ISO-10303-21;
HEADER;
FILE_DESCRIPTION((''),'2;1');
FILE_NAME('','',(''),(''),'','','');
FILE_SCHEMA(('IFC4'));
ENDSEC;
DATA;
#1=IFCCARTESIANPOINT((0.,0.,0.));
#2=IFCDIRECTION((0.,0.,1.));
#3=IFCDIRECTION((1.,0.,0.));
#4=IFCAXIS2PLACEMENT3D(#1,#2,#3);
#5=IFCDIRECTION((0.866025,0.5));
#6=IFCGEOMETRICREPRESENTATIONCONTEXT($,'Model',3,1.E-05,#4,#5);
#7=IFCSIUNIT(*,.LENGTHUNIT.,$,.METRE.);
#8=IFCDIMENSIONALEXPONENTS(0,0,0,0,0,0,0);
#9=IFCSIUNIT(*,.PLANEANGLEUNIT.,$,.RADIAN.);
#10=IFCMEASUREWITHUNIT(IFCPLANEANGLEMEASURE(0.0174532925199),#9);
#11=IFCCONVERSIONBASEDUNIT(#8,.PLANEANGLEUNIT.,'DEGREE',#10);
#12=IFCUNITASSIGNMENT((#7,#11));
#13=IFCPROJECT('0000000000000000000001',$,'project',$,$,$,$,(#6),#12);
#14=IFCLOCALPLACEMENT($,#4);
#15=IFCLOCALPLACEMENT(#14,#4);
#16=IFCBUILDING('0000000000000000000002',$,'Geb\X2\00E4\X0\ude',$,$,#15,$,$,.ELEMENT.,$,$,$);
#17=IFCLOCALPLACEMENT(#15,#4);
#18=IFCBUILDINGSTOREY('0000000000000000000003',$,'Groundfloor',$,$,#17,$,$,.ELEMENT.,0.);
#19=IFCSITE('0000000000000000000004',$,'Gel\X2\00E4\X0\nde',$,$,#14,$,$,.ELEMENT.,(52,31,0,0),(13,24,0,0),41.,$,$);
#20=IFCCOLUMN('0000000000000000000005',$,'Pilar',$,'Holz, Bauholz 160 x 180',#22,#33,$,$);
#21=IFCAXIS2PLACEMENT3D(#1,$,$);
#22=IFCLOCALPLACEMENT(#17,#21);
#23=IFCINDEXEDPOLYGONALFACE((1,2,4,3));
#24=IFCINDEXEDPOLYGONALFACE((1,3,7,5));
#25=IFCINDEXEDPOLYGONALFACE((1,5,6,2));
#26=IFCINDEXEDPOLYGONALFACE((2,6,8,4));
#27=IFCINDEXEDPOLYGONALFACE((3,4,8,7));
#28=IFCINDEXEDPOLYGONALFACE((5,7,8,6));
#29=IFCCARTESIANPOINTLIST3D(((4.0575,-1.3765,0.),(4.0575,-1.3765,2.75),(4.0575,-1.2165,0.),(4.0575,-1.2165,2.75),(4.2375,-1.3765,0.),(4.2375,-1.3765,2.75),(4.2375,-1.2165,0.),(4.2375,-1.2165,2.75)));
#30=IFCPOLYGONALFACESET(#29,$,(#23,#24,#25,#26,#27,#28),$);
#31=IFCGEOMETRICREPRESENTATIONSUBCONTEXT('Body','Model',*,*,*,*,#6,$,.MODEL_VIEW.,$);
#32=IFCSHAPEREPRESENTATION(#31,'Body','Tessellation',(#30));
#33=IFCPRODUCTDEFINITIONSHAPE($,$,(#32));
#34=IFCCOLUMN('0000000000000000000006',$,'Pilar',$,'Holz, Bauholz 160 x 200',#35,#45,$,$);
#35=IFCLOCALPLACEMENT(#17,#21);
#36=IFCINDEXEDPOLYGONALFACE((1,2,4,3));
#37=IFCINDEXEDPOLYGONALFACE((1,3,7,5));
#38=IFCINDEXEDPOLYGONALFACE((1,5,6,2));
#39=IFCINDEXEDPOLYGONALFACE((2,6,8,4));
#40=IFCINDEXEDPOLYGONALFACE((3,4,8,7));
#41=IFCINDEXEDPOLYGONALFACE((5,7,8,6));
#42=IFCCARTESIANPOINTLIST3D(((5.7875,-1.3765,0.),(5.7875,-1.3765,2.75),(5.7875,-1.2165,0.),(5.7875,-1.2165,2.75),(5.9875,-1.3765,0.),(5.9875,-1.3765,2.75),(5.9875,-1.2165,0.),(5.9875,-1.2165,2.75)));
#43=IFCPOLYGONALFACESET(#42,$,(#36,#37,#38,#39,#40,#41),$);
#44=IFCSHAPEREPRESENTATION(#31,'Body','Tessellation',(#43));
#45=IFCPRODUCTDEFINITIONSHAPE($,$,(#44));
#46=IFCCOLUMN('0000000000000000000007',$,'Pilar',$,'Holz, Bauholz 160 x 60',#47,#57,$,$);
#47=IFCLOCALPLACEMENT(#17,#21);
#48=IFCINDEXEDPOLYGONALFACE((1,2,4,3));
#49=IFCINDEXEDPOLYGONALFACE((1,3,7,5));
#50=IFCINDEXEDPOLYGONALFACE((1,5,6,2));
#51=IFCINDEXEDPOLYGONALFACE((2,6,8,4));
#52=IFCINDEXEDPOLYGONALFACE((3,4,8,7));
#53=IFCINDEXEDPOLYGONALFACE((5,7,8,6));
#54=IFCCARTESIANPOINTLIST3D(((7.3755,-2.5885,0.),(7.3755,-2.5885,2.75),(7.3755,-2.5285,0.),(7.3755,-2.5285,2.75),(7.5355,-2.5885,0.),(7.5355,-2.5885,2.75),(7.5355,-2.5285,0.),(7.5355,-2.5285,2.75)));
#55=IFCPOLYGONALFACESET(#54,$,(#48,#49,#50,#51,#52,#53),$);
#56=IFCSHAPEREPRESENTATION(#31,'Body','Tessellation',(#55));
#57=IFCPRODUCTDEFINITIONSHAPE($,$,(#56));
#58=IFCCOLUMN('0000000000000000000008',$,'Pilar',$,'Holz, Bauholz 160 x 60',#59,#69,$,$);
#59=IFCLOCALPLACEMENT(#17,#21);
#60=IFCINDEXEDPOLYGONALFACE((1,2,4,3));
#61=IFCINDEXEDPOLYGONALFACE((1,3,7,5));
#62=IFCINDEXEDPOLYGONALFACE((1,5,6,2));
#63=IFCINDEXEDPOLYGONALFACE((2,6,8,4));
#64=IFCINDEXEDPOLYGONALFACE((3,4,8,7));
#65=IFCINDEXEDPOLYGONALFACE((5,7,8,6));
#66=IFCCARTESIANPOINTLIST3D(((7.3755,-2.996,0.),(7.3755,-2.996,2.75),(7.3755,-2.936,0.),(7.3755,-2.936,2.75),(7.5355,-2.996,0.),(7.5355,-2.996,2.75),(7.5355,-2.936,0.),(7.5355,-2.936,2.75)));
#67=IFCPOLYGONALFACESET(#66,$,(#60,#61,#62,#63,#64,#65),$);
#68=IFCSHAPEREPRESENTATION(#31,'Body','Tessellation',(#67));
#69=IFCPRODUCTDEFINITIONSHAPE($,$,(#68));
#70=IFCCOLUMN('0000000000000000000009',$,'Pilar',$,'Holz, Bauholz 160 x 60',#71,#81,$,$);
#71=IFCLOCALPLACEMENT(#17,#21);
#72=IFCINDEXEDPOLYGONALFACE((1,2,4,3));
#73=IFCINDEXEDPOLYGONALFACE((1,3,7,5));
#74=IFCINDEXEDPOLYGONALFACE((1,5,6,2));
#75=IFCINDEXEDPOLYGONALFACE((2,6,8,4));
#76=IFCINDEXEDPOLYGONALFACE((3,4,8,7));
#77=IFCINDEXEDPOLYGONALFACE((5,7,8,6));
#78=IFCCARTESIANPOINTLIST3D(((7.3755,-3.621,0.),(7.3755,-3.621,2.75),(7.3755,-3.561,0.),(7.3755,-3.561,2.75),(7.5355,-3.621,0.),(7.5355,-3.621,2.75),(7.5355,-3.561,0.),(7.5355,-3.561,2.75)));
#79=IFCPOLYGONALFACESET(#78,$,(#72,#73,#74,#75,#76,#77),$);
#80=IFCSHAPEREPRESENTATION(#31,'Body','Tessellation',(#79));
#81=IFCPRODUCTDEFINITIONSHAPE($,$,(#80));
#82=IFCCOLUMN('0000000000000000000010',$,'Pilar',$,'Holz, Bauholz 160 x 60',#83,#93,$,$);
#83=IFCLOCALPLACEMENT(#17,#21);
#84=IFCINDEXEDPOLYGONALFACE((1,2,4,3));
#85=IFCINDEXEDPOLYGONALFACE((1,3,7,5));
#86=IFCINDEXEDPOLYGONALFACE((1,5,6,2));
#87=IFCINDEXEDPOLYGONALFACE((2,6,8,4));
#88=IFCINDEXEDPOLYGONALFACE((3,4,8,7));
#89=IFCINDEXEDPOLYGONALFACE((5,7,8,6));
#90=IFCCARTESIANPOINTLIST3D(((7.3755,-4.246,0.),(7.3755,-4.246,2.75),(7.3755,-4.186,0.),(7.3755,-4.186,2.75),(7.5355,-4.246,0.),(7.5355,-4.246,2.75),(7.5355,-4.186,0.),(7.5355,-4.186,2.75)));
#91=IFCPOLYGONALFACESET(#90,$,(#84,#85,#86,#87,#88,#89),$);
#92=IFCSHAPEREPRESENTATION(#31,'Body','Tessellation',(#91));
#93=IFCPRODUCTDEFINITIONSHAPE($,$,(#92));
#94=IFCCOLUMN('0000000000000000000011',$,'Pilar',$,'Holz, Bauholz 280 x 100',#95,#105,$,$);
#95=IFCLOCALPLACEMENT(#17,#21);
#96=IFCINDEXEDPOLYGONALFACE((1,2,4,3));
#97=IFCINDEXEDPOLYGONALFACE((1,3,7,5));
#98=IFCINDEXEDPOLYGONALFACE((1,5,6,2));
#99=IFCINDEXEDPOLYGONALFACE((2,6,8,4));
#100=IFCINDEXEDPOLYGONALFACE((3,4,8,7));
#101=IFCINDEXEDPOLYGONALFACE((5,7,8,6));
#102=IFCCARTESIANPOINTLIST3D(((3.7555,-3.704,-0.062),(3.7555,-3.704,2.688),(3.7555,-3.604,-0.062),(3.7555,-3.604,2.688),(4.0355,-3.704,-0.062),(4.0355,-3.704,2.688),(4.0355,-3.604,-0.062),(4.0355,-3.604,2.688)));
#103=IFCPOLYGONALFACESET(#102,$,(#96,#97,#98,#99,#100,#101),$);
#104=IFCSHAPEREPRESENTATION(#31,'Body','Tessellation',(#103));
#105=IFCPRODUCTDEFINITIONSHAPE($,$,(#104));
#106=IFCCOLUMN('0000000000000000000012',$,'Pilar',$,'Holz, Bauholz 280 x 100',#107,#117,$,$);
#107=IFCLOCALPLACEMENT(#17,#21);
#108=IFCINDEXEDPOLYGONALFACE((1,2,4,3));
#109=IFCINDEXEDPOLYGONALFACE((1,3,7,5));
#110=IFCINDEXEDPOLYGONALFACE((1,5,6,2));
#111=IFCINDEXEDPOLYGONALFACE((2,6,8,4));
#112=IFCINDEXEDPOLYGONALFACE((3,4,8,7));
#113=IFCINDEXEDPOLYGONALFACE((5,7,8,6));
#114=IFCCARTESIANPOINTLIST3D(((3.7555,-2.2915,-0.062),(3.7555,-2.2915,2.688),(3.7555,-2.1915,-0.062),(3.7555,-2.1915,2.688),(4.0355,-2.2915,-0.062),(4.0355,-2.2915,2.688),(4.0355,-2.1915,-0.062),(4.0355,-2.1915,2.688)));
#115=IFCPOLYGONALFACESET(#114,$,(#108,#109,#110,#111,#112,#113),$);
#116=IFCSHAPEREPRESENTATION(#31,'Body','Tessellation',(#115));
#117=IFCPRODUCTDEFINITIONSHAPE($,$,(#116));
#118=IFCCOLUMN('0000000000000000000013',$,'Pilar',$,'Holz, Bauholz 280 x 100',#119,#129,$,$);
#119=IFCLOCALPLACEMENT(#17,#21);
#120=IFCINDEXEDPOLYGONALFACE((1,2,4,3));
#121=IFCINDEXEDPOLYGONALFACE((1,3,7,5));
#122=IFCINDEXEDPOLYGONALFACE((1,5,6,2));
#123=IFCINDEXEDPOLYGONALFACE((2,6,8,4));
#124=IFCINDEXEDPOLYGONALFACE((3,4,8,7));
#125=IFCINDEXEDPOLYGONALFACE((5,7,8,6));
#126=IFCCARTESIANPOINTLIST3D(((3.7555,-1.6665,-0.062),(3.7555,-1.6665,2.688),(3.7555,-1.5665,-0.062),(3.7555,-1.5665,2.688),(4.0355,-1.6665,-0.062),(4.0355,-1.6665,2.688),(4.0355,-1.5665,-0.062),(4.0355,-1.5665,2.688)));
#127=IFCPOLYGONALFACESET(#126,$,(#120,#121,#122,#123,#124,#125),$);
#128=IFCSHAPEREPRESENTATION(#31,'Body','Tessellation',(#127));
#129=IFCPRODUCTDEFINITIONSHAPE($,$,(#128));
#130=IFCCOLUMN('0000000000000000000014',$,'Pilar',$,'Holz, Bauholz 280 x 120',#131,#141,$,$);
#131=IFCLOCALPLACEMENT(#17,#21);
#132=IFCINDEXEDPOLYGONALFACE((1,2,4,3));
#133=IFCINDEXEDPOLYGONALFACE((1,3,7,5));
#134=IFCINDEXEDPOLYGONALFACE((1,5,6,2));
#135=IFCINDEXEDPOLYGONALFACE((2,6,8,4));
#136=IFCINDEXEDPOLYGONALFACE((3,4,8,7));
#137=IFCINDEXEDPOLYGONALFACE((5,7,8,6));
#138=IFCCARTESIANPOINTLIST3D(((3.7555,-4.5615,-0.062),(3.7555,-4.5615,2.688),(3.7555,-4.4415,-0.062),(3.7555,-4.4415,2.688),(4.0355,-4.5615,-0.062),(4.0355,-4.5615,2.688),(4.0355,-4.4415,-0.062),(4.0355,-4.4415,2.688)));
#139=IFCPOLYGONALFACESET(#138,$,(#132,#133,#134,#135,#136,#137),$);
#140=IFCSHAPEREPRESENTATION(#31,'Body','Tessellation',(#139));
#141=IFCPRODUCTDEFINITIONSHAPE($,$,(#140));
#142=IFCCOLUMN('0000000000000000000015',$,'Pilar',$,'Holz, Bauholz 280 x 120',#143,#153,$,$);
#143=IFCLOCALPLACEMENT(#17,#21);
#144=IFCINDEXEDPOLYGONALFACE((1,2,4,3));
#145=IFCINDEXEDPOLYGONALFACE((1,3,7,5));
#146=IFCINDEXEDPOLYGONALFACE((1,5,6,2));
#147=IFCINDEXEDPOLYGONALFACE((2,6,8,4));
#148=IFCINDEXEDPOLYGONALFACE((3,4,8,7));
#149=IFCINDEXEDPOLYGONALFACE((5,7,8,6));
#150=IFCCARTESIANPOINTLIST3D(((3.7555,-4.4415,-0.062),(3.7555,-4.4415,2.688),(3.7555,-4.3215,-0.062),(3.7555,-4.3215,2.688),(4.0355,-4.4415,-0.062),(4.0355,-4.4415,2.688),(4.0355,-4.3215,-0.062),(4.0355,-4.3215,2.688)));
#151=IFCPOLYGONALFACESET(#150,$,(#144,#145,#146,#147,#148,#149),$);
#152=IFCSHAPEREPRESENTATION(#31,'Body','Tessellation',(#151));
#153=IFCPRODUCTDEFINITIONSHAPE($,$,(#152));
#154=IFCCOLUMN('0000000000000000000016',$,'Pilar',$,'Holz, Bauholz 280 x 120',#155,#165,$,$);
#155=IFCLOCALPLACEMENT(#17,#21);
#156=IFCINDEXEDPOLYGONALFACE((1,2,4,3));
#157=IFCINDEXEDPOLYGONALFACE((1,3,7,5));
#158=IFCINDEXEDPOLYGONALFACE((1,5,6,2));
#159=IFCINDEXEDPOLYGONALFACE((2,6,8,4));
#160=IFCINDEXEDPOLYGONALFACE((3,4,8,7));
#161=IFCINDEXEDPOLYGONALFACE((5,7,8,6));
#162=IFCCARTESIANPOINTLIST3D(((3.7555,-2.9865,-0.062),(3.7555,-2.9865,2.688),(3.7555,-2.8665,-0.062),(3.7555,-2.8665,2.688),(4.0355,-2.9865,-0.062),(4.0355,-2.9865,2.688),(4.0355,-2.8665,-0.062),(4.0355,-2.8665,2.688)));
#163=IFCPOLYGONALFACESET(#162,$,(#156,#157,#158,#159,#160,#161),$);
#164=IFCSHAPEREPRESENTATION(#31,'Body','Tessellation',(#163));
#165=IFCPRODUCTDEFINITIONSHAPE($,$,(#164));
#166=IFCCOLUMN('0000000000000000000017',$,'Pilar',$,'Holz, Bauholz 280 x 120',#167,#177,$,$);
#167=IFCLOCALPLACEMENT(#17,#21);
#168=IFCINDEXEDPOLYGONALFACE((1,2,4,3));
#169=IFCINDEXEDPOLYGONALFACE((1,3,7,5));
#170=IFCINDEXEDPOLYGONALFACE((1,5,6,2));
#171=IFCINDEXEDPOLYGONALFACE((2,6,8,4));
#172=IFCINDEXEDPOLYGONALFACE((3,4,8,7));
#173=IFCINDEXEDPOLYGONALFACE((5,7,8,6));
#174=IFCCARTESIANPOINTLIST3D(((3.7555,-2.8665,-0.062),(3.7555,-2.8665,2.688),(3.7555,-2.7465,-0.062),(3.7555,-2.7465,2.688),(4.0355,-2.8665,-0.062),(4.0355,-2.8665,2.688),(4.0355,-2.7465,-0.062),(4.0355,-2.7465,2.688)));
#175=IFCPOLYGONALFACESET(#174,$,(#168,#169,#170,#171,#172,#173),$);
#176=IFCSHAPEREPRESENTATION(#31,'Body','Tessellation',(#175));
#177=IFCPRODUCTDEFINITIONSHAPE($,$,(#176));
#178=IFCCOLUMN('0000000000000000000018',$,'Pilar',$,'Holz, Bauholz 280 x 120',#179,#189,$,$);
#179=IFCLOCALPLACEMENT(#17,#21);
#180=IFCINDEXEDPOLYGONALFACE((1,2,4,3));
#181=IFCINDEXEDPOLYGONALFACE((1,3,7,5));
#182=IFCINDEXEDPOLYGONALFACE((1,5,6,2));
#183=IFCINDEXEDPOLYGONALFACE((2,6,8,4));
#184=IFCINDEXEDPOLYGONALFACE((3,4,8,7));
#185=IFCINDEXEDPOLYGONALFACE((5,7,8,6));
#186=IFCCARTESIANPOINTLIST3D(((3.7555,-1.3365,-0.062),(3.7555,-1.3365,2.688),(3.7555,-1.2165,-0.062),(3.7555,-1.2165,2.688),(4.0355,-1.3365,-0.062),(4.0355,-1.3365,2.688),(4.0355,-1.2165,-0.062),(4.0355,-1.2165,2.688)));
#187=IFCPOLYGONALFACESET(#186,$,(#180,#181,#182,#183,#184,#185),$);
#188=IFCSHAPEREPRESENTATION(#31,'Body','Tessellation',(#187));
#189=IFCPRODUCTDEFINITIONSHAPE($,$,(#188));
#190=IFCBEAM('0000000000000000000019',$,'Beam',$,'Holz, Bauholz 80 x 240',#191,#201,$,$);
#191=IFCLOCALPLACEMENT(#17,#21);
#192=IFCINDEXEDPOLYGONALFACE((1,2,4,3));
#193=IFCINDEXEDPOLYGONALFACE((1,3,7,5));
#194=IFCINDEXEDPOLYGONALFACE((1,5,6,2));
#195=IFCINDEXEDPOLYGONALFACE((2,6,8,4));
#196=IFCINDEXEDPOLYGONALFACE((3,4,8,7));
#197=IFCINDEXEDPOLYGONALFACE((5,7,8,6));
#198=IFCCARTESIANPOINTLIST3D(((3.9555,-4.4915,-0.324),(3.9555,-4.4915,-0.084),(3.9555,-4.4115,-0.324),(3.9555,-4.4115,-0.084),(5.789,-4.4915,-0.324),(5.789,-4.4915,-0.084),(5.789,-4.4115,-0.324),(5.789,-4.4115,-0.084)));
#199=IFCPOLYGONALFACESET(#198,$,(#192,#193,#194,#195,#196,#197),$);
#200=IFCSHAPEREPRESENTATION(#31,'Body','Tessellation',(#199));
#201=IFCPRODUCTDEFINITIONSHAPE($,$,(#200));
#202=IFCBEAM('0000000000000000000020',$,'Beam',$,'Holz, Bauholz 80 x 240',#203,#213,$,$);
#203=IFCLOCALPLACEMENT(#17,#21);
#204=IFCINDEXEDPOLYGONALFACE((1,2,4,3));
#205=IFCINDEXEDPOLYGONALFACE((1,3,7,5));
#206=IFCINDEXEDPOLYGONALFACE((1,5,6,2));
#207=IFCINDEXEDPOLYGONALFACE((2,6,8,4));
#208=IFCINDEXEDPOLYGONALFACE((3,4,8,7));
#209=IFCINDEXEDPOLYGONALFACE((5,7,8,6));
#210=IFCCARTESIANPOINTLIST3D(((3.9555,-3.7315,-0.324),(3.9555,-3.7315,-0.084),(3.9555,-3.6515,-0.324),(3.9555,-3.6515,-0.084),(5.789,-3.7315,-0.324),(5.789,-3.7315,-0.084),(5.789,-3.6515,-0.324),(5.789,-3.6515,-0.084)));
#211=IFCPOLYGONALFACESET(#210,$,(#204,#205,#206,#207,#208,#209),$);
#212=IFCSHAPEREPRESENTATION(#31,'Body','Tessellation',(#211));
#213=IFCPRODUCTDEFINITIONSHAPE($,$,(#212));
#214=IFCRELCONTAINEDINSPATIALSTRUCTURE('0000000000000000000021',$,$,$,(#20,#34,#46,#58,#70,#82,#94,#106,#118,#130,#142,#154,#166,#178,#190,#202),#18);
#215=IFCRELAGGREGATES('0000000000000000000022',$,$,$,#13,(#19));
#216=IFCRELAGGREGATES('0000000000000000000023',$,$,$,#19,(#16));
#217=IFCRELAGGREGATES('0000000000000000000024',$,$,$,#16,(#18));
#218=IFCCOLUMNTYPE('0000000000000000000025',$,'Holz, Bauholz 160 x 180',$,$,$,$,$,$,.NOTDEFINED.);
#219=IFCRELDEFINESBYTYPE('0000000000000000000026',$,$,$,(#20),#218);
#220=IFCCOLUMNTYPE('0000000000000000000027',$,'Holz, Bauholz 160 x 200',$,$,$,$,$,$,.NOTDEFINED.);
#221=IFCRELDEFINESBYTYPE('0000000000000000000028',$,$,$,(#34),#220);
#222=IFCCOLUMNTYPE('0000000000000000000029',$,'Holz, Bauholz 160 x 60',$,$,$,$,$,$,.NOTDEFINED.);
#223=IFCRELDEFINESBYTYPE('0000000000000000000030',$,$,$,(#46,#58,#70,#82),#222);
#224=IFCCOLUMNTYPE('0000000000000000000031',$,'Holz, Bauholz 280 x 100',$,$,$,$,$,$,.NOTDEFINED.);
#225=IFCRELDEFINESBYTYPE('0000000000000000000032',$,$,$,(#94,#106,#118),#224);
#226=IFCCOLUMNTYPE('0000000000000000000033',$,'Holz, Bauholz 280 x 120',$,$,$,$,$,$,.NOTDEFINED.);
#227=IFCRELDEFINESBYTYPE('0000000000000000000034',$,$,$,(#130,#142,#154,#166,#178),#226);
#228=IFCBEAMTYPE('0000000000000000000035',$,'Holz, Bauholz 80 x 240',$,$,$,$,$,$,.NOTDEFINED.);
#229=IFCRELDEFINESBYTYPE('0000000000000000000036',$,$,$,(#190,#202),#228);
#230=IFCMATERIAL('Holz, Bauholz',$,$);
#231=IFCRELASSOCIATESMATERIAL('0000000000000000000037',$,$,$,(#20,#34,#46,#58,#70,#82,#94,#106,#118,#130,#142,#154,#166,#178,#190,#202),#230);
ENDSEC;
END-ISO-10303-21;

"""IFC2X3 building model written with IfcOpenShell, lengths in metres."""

from ifc_helpers import new_model, entity, si_unit, converted_unit, direction, frame, frame_2d, origin_with_axes, origin_2d_with_axis, place, context, subcontext, project, spatial, rectangle, extrude, clip, halfspace, material, type_object, element, save


model = new_model("IFC2X3")

# Units and contexts
model_context = context("Model", 3, precision=1e-05, world=origin_with_axes(), true_north=direction((0.866025, 0.5)))
body_context = subcontext(model_context, "Body", "Model", "MODEL_VIEW")
ifc_project = project(units=[si_unit("LENGTHUNIT", "METRE"), converted_unit("PLANEANGLEUNIT", "DEGREE", entity("IfcPlaneAngleMeasure", 0.0174532925199), si_unit("PLANEANGLEUNIT", "RADIAN"), dimensions=[0, 0, 0, 0, 0, 0, 0])], contexts=[model_context])

# Site, building, storey
site_placement = place(None, origin_with_axes())
site = spatial("IfcSite", under=ifc_project, at=site_placement, Name="Gelände", CompositionType="ELEMENT", RefLatitude=(52, 31, 0, 0), RefLongitude=(13, 24, 0, 0), RefElevation=41.0)
building_placement = place(site_placement, origin_with_axes())
building = spatial("IfcBuilding", under=site, at=building_placement, Name="Gebäude", CompositionType="ELEMENT")
storey_placement = place(building_placement, origin_with_axes())
storey = spatial("IfcBuildingStorey", under=building, at=storey_placement, Name="Groundfloor", CompositionType="ELEMENT", Elevation=0.0)

# Columns
ifc_material_1 = material(Name="Holz, Bauholz")
column_type_1 = type_object("IfcColumnType", Name="Holz, Bauholz 160 x 180", PredefinedType="NOTDEFINED")
column_1_placement = place(storey_placement, frame((4.1475, -1.2965, 0.0), z_axis=(0.0, 0.0, 1.0), x_axis=(1.0, 0.0, 0.0)))
element("IfcColumn", 1, at=column_1_placement, inside=storey, type_object=column_type_1, material=ifc_material_1, Name="Pilar", ObjectType="Holz, Bauholz 160 x 180", context=body_context, shape_type="Clipping", body=[
    clip(clip(extrude(rectangle(XDim=0.16, YDim=0.18, at=origin_2d_with_axis()), frame((0.0, 0.0, 0.0), z_axis=(0.0, 0.0, 1.0), x_axis=(0.0, 1.0, 0.0)), (0.0, 0.0, 1.0), 2.75), halfspace(frame((0.0, 0.0, 2.75), z_axis=(0.0, 0.0, -1.0), x_axis=(0.0, 1.0, 0.0)), True)), halfspace(frame((0.0, 0.0, 0.0), z_axis=(0.0, 0.0, 1.0), x_axis=(0.0, -1.0, 0.0)), True)),
])
column_type_2 = type_object("IfcColumnType", Name="Holz, Bauholz 160 x 200", PredefinedType="NOTDEFINED")
column_2_placement = place(storey_placement, frame((5.8875, -1.2965, 0.0), z_axis=(0.0, 0.0, 1.0), x_axis=(1.0, 0.0, 0.0)))
element("IfcColumn", 2, at=column_2_placement, inside=storey, type_object=column_type_2, material=ifc_material_1, Name="Pilar", ObjectType="Holz, Bauholz 160 x 200", context=body_context, shape_type="Clipping", body=[
    clip(clip(extrude(rectangle(XDim=0.16, YDim=0.2, at=origin_2d_with_axis()), frame((0.0, 0.0, 0.0), z_axis=(0.0, 0.0, 1.0), x_axis=(0.0, 1.0, 0.0)), (0.0, 0.0, 1.0), 2.75), halfspace(frame((0.0, 0.0, 2.75), z_axis=(0.0, 0.0, -1.0), x_axis=(0.0, 1.0, 0.0)), True)), halfspace(frame((0.0, 0.0, 0.0), z_axis=(0.0, 0.0, 1.0), x_axis=(0.0, -1.0, 0.0)), True)),
])
column_type_3 = type_object("IfcColumnType", Name="Holz, Bauholz 160 x 60", PredefinedType="NOTDEFINED")
for number, where, z_axis, x_axis, name in (
    (3, (7.4555, -2.5585, 0.0), (0.0, 0.0, 1.0), (0.0, -1.0, 0.0), "Pilar"),
    (4, (7.4555, -2.966, 0.0), (0.0, 0.0, 1.0), (0.0, -1.0, 0.0), "Pilar"),
    (5, (7.4555, -3.591, 0.0), (0.0, 0.0, 1.0), (0.0, -1.0, 0.0), "Pilar"),
    (6, (7.4555, -4.216, 0.0), (0.0, 0.0, 1.0), (0.0, -1.0, 0.0), "Pilar"),
):
    element("IfcColumn", number, at=place(storey_placement, frame(where, z_axis=z_axis, x_axis=x_axis)), inside=storey, type_object=column_type_3, material=ifc_material_1, Name=name, ObjectType="Holz, Bauholz 160 x 60", context=body_context, shape_type="Clipping", body=[
        clip(clip(extrude(rectangle(XDim=0.16, YDim=0.06, at=origin_2d_with_axis()), frame((0.0, 0.0, 0.0), z_axis=(0.0, 0.0, 1.0), x_axis=(0.0, 1.0, 0.0)), (0.0, 0.0, 1.0), 2.75), halfspace(frame((0.0, 0.0, 2.75), z_axis=(0.0, 0.0, -1.0), x_axis=(0.0, 1.0, 0.0)), True)), halfspace(frame((0.0, 0.0, 0.0), z_axis=(0.0, 0.0, 1.0), x_axis=(0.0, -1.0, 0.0)), True)),
    ])
column_type_4 = type_object("IfcColumnType", Name="Holz, Bauholz 280 x 100", PredefinedType="NOTDEFINED")
for number, where, z_axis, x_axis, name in (
    (7, (3.8955, -3.654, -0.062), (0.0, 0.0, 1.0), (0.0, 1.0, 0.0), "Pilar"),
    (8, (3.8955, -2.2415, -0.062), (0.0, 0.0, 1.0), (0.0, 1.0, 0.0), "Pilar"),
    (9, (3.8955, -1.6165, -0.062), (0.0, 0.0, 1.0), (0.0, 1.0, 0.0), "Pilar"),
):
    element("IfcColumn", number, at=place(storey_placement, frame(where, z_axis=z_axis, x_axis=x_axis)), inside=storey, type_object=column_type_4, material=ifc_material_1, Name=name, ObjectType="Holz, Bauholz 280 x 100", context=body_context, shape_type="Clipping", body=[
        clip(clip(extrude(rectangle(XDim=0.28, YDim=0.1, at=origin_2d_with_axis()), frame((0.0, 0.0, 0.0), z_axis=(0.0, 0.0, 1.0), x_axis=(0.0, 1.0, 0.0)), (0.0, 0.0, 1.0), 2.75), halfspace(frame((0.0, 0.0, 2.75), z_axis=(0.0, 0.0, -1.0), x_axis=(0.0, 1.0, 0.0)), True)), halfspace(frame((0.0, 0.0, 0.0), z_axis=(0.0, 0.0, 1.0), x_axis=(0.0, -1.0, 0.0)), True)),
    ])
column_type_5 = type_object("IfcColumnType", Name="Holz, Bauholz 280 x 120", PredefinedType="NOTDEFINED")
for number, where, z_axis, x_axis, name in (
    (10, (3.8955, -4.5015, -0.062), (0.0, 0.0, 1.0), (0.0, 1.0, 0.0), "Pilar"),
    (11, (3.8955, -4.3815, -0.062), (0.0, 0.0, 1.0), (0.0, 1.0, 0.0), "Pilar"),
    (12, (3.8955, -2.9265, -0.062), (0.0, 0.0, 1.0), (0.0, 1.0, 0.0), "Pilar"),
    (13, (3.8955, -2.8065, -0.062), (0.0, 0.0, 1.0), (0.0, 1.0, 0.0), "Pilar"),
    (14, (3.8955, -1.2765, -0.062), (0.0, 0.0, 1.0), (0.0, 1.0, 0.0), "Pilar"),
):
    element("IfcColumn", number, at=place(storey_placement, frame(where, z_axis=z_axis, x_axis=x_axis)), inside=storey, type_object=column_type_5, material=ifc_material_1, Name=name, ObjectType="Holz, Bauholz 280 x 120", context=body_context, shape_type="Clipping", body=[
        clip(clip(extrude(rectangle(XDim=0.28, YDim=0.12, at=origin_2d_with_axis()), frame((0.0, 0.0, 0.0), z_axis=(0.0, 0.0, 1.0), x_axis=(0.0, 1.0, 0.0)), (0.0, 0.0, 1.0), 2.75), halfspace(frame((0.0, 0.0, 2.75), z_axis=(0.0, 0.0, -1.0), x_axis=(0.0, 1.0, 0.0)), True)), halfspace(frame((0.0, 0.0, 0.0), z_axis=(0.0, 0.0, 1.0), x_axis=(0.0, -1.0, 0.0)), True)),
    ])

# Beams
beam_type = type_object("IfcBeamType", Name="Holz, Bauholz 80 x 240", PredefinedType="NOTDEFINED")
for number, where, z_axis, x_axis, name in (
    (15, (5.789, -4.4515, -0.084), (0.0, 0.0, 1.0), (0.0, 1.0, 0.0), "Beam"),
    (16, (5.789, -3.6915, -0.084), (0.0, 0.0, 1.0), (0.0, 1.0, 0.0), "Beam"),
):
    element("IfcBeam", number, at=place(storey_placement, frame(where, z_axis=z_axis, x_axis=x_axis)), inside=storey, type_object=beam_type, material=ifc_material_1, Name=name, ObjectType="Holz, Bauholz 80 x 240", context=body_context, shape_type="SweptSolid", body=[
        extrude(rectangle(XDim=0.24, YDim=0.08, at=frame_2d((-0.12, 0.0), x_axis=(1.0, 0.0))), frame((0.0, 0.0, 0.0), z_axis=(0.0, 1.0, 0.0), x_axis=(0.0, 0.0, 1.0)), (0.0, 0.0, 1.0), 1.8335),
    ])

save(model, "model.ifc")
